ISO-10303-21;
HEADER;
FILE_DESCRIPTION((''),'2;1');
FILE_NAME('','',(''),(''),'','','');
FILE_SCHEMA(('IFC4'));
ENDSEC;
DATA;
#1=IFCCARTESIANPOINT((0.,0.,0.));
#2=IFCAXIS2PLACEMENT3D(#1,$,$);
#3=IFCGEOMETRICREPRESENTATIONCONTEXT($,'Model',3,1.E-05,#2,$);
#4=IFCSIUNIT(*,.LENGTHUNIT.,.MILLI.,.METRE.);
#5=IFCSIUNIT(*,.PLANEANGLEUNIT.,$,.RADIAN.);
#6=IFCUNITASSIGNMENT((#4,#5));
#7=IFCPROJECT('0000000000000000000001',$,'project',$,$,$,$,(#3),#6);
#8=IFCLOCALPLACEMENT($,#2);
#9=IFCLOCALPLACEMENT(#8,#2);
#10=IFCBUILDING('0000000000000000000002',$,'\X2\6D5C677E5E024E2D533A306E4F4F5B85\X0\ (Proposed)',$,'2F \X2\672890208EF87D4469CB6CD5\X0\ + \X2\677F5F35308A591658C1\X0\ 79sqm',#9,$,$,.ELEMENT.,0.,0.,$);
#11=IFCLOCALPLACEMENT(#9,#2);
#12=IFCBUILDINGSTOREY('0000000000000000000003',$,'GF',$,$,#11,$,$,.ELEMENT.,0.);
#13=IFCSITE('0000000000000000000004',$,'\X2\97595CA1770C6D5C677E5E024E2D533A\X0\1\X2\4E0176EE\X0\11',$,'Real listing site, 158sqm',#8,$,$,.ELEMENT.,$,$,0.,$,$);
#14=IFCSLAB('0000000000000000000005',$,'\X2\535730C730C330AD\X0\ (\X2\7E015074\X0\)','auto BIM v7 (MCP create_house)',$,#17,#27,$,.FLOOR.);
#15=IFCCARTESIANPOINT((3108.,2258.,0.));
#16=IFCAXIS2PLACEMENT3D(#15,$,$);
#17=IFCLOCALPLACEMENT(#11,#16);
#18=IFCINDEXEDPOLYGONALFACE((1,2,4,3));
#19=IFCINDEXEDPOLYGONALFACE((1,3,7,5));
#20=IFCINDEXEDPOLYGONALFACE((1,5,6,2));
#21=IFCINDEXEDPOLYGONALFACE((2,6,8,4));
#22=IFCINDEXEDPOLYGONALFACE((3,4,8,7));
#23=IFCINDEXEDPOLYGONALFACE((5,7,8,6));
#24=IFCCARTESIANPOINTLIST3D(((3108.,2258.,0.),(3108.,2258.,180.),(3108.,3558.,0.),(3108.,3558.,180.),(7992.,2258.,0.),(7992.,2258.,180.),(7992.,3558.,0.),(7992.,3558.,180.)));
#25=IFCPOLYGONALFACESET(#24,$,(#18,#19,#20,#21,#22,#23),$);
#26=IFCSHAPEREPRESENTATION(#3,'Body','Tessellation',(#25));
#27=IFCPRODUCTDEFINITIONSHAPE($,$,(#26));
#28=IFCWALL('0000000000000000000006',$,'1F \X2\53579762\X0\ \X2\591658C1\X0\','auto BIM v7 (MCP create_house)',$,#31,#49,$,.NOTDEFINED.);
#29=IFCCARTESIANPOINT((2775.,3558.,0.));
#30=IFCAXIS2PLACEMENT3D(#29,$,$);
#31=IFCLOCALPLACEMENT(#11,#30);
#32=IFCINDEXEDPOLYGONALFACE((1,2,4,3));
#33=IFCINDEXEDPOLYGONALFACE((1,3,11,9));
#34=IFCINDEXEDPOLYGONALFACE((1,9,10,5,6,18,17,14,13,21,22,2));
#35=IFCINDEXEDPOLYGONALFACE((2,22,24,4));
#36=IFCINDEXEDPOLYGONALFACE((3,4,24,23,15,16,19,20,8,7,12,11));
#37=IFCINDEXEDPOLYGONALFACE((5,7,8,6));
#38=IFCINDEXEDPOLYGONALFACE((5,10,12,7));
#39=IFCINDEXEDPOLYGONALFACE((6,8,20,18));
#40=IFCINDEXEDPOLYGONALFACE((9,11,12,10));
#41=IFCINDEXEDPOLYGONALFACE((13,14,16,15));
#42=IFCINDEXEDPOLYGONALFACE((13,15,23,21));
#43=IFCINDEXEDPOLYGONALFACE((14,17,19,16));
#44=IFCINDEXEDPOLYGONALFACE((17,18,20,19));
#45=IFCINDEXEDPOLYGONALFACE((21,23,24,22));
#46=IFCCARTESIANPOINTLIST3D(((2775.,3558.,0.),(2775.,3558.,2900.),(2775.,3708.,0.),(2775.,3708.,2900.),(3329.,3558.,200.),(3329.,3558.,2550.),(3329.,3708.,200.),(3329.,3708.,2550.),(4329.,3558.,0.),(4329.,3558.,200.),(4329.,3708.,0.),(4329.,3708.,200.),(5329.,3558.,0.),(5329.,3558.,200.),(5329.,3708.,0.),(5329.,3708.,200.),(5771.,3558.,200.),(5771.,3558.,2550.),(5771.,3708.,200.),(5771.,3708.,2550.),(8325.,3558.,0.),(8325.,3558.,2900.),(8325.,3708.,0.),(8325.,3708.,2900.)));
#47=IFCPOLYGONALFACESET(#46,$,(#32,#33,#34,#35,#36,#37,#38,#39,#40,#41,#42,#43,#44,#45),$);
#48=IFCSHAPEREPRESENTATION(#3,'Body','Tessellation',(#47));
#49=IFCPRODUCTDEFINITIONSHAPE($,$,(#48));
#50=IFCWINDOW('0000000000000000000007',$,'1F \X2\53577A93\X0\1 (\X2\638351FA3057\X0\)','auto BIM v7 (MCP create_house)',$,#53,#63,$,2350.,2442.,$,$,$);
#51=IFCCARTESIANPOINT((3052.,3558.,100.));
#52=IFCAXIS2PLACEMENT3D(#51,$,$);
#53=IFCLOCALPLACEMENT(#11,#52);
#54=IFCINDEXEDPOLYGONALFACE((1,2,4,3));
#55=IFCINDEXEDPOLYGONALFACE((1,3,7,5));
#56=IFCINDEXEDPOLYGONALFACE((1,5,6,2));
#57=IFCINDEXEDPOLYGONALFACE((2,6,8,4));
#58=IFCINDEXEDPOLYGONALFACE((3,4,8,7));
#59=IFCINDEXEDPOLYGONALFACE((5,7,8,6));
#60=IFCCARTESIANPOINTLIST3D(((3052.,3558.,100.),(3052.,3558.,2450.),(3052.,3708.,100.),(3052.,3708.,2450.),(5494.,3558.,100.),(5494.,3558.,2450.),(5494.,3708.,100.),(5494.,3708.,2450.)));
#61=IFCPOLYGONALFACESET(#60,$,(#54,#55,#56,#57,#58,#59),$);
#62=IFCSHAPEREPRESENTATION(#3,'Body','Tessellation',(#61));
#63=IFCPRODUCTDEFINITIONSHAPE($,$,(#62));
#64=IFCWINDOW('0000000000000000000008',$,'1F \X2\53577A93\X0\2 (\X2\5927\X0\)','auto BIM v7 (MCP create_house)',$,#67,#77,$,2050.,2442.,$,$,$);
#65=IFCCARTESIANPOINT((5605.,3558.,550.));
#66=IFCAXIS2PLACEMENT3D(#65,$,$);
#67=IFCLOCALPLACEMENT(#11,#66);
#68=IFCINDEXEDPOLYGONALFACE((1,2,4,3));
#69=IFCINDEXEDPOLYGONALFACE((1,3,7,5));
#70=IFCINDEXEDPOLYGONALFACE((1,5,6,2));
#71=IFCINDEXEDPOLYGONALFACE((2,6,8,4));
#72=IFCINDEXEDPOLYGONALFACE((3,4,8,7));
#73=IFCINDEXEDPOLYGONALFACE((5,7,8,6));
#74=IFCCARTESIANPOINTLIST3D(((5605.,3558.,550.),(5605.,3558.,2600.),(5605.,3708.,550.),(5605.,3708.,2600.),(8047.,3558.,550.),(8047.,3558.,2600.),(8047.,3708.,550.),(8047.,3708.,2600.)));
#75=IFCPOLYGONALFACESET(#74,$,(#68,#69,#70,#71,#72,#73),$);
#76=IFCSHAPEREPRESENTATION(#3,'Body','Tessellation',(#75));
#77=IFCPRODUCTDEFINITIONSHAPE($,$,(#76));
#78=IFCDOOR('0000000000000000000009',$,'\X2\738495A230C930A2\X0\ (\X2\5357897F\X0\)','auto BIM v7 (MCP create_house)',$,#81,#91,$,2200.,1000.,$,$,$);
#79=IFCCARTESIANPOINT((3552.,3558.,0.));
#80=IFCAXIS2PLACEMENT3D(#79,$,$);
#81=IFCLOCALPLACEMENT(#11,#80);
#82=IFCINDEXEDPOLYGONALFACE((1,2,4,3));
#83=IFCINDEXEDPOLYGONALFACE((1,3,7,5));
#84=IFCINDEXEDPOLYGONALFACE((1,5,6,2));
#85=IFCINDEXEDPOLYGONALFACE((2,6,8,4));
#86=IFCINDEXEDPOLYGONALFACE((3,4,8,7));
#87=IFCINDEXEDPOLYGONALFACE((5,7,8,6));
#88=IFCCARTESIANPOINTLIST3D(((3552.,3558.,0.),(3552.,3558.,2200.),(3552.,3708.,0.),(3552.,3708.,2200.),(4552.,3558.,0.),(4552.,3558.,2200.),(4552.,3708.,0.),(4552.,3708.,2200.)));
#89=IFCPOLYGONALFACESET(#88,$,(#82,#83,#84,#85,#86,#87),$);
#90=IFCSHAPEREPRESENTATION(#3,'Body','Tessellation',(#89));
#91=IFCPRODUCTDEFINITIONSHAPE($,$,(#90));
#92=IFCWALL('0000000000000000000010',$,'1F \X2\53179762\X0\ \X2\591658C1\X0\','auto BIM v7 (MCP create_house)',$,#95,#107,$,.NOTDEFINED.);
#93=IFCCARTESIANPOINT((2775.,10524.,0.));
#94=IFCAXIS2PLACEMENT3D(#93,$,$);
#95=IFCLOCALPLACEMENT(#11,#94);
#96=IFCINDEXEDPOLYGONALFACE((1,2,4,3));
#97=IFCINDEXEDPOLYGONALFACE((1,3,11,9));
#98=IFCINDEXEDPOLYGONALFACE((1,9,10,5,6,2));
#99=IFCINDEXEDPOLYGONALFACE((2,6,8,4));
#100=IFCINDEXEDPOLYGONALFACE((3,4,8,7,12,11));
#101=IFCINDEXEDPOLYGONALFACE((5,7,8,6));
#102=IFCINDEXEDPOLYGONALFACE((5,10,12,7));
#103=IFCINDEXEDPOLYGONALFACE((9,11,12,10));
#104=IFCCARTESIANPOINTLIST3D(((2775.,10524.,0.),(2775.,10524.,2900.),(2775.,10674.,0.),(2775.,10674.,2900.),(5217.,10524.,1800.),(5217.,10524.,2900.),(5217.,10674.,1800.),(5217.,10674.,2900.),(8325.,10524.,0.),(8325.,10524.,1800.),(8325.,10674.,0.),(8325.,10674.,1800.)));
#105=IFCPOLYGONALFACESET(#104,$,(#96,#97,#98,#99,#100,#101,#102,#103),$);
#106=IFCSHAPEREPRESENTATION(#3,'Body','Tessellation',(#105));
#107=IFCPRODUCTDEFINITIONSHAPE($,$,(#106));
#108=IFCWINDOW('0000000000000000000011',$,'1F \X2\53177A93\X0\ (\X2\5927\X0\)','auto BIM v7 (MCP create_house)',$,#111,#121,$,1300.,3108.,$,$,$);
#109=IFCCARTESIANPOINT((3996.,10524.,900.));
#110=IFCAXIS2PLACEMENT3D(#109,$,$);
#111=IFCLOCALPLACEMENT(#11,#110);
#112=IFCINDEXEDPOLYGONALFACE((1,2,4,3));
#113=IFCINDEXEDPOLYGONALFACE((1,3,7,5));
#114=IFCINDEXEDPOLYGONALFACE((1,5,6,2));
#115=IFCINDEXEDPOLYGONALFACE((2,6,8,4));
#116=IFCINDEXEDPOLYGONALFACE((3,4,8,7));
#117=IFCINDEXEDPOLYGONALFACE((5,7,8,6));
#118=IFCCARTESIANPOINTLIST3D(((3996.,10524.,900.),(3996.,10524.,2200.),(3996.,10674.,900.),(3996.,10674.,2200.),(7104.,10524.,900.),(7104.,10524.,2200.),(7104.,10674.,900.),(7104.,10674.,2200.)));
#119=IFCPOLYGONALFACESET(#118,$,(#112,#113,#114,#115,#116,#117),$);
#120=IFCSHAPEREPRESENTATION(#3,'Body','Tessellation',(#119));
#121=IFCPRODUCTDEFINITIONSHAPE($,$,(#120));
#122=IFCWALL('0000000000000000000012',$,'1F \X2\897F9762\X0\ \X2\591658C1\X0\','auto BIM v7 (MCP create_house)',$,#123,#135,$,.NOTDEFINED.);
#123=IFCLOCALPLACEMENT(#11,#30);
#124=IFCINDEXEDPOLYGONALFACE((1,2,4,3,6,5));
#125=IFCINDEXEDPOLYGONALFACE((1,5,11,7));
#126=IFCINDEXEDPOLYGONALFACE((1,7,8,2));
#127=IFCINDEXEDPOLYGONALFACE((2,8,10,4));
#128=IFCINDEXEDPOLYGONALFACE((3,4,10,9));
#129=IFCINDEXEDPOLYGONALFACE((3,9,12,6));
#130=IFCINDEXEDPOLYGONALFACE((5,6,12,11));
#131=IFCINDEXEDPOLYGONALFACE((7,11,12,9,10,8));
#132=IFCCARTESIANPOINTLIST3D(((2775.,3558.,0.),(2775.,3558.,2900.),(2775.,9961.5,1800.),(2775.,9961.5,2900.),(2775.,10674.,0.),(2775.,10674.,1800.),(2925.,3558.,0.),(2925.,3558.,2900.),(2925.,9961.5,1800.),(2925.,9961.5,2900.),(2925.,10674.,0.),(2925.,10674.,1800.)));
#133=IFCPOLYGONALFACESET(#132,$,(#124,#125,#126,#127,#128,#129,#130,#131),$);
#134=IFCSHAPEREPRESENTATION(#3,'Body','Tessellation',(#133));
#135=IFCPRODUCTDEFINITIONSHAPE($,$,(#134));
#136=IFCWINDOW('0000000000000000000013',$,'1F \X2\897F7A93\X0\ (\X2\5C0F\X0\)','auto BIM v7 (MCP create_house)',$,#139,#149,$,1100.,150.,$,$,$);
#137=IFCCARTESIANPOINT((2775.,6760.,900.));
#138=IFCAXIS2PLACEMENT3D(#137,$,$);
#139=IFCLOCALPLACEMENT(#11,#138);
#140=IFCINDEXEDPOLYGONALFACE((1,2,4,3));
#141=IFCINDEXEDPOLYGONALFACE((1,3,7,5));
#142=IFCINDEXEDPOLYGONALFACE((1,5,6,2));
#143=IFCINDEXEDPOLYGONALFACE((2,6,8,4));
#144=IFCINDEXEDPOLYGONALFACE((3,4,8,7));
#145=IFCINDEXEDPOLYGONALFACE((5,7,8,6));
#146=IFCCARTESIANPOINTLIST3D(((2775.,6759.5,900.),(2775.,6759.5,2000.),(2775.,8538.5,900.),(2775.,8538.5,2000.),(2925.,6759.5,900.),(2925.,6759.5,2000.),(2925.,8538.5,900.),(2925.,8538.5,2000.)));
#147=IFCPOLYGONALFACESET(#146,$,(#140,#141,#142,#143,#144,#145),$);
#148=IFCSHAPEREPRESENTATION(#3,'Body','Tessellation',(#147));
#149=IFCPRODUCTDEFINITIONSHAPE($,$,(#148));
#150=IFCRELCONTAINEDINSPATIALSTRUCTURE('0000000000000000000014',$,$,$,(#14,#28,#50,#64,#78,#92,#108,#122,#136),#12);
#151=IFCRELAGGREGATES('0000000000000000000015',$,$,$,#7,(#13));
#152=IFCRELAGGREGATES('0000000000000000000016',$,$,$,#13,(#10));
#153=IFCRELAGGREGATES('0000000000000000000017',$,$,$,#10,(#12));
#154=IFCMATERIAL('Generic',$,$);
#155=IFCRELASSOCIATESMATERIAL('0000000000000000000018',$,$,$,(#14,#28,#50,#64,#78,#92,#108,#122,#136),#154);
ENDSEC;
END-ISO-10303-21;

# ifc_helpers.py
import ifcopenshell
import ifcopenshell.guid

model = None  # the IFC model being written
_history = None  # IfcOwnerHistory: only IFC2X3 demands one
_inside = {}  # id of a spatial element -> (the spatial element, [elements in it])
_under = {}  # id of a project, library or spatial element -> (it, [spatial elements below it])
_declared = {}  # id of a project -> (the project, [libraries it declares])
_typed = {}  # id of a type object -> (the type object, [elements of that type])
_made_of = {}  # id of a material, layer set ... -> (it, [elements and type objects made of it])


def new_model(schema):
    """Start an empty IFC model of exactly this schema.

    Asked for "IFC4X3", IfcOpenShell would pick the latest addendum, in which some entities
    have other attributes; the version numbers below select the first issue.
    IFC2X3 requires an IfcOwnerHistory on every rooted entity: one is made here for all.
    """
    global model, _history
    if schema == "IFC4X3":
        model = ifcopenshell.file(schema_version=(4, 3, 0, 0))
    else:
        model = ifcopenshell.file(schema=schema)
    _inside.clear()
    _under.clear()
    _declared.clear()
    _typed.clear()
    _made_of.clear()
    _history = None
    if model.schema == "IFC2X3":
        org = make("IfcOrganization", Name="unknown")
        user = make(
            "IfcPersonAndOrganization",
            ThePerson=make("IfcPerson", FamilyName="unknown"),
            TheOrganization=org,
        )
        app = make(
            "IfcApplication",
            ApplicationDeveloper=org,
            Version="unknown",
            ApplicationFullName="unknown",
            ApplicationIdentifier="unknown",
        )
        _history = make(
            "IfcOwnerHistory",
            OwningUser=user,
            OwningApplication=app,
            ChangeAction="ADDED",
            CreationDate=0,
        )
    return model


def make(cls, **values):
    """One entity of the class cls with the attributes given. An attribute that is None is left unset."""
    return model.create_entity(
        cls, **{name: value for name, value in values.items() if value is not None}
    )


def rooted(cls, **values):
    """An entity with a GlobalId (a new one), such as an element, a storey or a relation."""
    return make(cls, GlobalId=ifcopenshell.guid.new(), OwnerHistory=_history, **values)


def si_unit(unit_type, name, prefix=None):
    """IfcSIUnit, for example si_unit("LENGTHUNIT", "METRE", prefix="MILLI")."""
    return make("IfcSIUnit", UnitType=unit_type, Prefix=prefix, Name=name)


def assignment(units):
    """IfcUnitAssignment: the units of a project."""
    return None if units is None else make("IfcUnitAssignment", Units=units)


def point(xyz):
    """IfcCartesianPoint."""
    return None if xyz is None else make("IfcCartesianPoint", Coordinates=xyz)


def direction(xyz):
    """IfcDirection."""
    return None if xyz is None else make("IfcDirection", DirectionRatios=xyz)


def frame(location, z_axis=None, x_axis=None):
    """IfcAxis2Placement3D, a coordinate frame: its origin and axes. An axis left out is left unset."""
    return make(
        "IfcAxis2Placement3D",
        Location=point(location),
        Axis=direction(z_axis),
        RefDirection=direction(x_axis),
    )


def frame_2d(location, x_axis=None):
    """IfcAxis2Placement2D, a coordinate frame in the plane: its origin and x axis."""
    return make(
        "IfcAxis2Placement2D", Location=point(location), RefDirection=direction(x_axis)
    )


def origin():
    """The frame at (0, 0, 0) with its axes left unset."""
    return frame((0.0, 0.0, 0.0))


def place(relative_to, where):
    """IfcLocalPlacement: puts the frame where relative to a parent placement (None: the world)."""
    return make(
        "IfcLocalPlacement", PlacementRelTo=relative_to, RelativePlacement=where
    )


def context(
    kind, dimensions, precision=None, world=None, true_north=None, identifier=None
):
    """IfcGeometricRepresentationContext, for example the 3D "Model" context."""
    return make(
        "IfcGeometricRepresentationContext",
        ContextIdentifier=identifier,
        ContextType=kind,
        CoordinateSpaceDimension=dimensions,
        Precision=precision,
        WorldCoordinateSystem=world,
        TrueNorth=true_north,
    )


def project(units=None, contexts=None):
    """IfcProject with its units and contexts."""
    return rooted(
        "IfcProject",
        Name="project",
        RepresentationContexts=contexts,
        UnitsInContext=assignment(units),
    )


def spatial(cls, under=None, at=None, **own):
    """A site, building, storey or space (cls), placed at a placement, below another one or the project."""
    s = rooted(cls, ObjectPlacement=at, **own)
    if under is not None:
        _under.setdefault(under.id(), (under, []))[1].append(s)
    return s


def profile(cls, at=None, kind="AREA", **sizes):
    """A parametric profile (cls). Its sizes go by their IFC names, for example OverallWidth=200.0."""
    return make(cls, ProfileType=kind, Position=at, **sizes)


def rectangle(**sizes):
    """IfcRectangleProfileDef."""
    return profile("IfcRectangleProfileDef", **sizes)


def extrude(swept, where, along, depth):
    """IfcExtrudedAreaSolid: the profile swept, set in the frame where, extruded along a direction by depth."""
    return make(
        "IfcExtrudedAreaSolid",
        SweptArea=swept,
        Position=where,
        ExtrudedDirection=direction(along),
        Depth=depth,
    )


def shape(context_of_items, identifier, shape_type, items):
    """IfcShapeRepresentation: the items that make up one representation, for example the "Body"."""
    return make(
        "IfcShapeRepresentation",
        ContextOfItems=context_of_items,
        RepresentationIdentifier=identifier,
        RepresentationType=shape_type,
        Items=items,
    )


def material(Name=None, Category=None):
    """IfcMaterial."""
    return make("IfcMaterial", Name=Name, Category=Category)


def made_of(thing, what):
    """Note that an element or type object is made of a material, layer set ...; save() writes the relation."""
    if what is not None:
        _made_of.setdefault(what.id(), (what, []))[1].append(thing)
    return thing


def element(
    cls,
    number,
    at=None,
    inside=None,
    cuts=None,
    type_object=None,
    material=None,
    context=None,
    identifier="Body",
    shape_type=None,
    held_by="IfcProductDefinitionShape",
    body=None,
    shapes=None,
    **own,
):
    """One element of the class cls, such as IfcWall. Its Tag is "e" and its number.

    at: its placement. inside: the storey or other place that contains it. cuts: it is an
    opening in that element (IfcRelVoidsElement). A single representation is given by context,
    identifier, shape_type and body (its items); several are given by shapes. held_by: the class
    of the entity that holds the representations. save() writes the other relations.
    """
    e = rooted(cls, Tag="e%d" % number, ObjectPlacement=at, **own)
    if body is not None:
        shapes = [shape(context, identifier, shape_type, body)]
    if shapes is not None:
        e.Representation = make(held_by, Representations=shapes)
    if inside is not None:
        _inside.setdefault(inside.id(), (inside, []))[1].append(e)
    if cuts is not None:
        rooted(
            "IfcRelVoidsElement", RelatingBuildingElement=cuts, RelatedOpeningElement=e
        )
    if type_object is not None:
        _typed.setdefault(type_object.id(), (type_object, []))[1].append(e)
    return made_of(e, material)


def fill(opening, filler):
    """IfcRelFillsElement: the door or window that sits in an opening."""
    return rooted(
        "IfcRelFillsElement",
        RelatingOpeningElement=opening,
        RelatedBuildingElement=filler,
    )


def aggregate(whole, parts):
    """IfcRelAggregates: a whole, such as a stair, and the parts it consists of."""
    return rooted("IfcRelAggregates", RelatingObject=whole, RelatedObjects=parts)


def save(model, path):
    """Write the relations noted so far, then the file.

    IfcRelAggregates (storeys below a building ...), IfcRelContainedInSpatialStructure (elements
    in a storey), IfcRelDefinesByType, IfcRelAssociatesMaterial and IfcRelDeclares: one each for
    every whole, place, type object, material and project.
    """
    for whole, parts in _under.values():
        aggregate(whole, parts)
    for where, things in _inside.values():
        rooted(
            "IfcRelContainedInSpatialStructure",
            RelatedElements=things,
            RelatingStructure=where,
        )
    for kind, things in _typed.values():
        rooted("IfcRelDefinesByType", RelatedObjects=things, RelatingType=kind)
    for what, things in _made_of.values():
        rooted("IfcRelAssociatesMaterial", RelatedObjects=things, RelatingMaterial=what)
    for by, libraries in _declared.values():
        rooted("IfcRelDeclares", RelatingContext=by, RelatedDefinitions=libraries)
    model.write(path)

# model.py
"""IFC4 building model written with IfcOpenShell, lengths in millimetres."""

from ifc_helpers import new_model, si_unit, frame, frame_2d, origin, place, context, project, spatial, rectangle, extrude, material, element, fill, save


model = new_model("IFC4")

# Units and contexts
model_context = context("Model", 3, precision=1e-05, world=origin())
ifc_project = project(units=[si_unit("LENGTHUNIT", "METRE", prefix="MILLI"), si_unit("PLANEANGLEUNIT", "RADIAN")], contexts=[model_context])

# Site, building, storey
site_placement = place(None, origin())
site = spatial("IfcSite", under=ifc_project, at=site_placement, Name="静岡県浜松市中区1丁目11", ObjectType="Real listing site, 158sqm", CompositionType="ELEMENT", RefElevation=0.0)
building_placement = place(site_placement, origin())
building = spatial("IfcBuilding", under=site, at=building_placement, Name="浜松市中区の住宅 (Proposed)", ObjectType="2F 木造軸組構法 + 板張り外壁 79sqm", CompositionType="ELEMENT", ElevationOfRefHeight=0.0, ElevationOfTerrain=0.0)
storey_placement = place(building_placement, origin())
storey = spatial("IfcBuildingStorey", under=building, at=storey_placement, Name="GF", CompositionType="ELEMENT", Elevation=0.0)

# Slab
ifc_material = material(Name="Generic")
slab_1_placement = place(storey_placement, frame((3108.0, 2258.0, 0.0)))
element("IfcSlab", 1, at=slab_1_placement, inside=storey, material=ifc_material, Name="南デッキ (縁側)", Description="auto BIM v7 (MCP create_house)", PredefinedType="FLOOR", context=model_context, shape_type="SweptSolid", body=[
    extrude(rectangle(XDim=4884.0, YDim=1300.0, at=frame_2d((2442.0, 650.0))), frame((3108.0, 2258.0, 0.0)), (0.0, 0.0, 1.0), 180.0),
])

# Wall, openings, windows, door
wall_1_placement = place(storey_placement, frame((2775.0, 3558.0, 0.0)))
wall_1 = element("IfcWall", 2, at=wall_1_placement, inside=storey, material=ifc_material, Name="1F 南面 外壁", Description="auto BIM v7 (MCP create_house)", PredefinedType="NOTDEFINED", context=model_context, shape_type="SweptSolid", body=[
    extrude(rectangle(XDim=5550.0, YDim=150.0, at=frame_2d((2775.0, 75.0))), frame((2775.0, 3558.0, 0.0)), (0.0, 0.0, 1.0), 2900.0),
])
opening_1_placement = place(storey_placement, frame((3052.0, 3558.0, 100.0)))
opening_1 = element("IfcOpeningElement", 3, at=opening_1_placement, cuts=wall_1, PredefinedType="NOTDEFINED", context=model_context, shape_type="SweptSolid", body=[
    extrude(rectangle(XDim=2442.0, YDim=150.0, at=frame_2d((1221.0, 75.0))), frame((3052.0, 3558.0, 100.0)), (0.0, 0.0, 1.0), 2350.0),
])
opening_2_placement = place(storey_placement, frame((5605.0, 3558.0, 550.0)))
opening_2 = element("IfcOpeningElement", 4, at=opening_2_placement, cuts=wall_1, PredefinedType="NOTDEFINED", context=model_context, shape_type="SweptSolid", body=[
    extrude(rectangle(XDim=2442.0, YDim=150.0, at=frame_2d((1221.0, 75.0))), frame((5605.0, 3558.0, 550.0)), (0.0, 0.0, 1.0), 2050.0),
])
opening_3_placement = place(storey_placement, frame((3552.0, 3558.0, 0.0)))
opening_3 = element("IfcOpeningElement", 5, at=opening_3_placement, cuts=wall_1, PredefinedType="NOTDEFINED", context=model_context, shape_type="SweptSolid", body=[
    extrude(rectangle(XDim=1000.0, YDim=150.0, at=frame_2d((500.0, 75.0))), frame((3552.0, 3558.0, 0.0)), (0.0, 0.0, 1.0), 2200.0),
])
window_1_placement = place(storey_placement, frame((3052.0, 3558.0, 100.0)))
window_1 = element("IfcWindow", 6, at=window_1_placement, inside=storey, material=ifc_material, Name="1F 南窓1 (掃出し)", Description="auto BIM v7 (MCP create_house)", OverallHeight=2350.0, OverallWidth=2442.0, context=model_context, shape_type="SweptSolid", body=[
    extrude(rectangle(XDim=2442.0, YDim=150.0, at=frame_2d((1221.0, 75.0))), frame((3052.0, 3558.0, 100.0)), (0.0, 0.0, 1.0), 2350.0),
])
fill(opening_1, window_1)
window_2_placement = place(storey_placement, frame((5605.0, 3558.0, 550.0)))
window_2 = element("IfcWindow", 7, at=window_2_placement, inside=storey, material=ifc_material, Name="1F 南窓2 (大)", Description="auto BIM v7 (MCP create_house)", OverallHeight=2050.0, OverallWidth=2442.0, context=model_context, shape_type="SweptSolid", body=[
    extrude(rectangle(XDim=2442.0, YDim=150.0, at=frame_2d((1221.0, 75.0))), frame((5605.0, 3558.0, 550.0)), (0.0, 0.0, 1.0), 2050.0),
])
fill(opening_2, window_2)
door_placement = place(storey_placement, frame((3552.0, 3558.0, 0.0)))
door = element("IfcDoor", 8, at=door_placement, inside=storey, material=ifc_material, Name="玄関ドア (南西)", Description="auto BIM v7 (MCP create_house)", OverallHeight=2200.0, OverallWidth=1000.0, context=model_context, shape_type="SweptSolid", body=[
    extrude(rectangle(XDim=1000.0, YDim=150.0, at=frame_2d((500.0, 75.0))), frame((3552.0, 3558.0, 0.0)), (0.0, 0.0, 1.0), 2200.0),
])
fill(opening_3, door)

# Walls, openings, windows
wall_2_placement = place(storey_placement, frame((2775.0, 10524.0, 0.0)))
wall_2 = element("IfcWall", 9, at=wall_2_placement, inside=storey, material=ifc_material, Name="1F 北面 外壁", Description="auto BIM v7 (MCP create_house)", PredefinedType="NOTDEFINED", context=model_context, shape_type="SweptSolid", body=[
    extrude(rectangle(XDim=5550.0, YDim=150.0, at=frame_2d((2775.0, 75.0))), frame((2775.0, 10524.0, 0.0)), (0.0, 0.0, 1.0), 2900.0),
])
opening_4_placement = place(storey_placement, frame((3996.0, 10524.0, 900.0)))
opening_4 = element("IfcOpeningElement", 10, at=opening_4_placement, cuts=wall_2, PredefinedType="NOTDEFINED", context=model_context, shape_type="SweptSolid", body=[
    extrude(rectangle(XDim=3108.0, YDim=150.0, at=frame_2d((1554.0, 75.0))), frame((3996.0, 10524.0, 900.0)), (0.0, 0.0, 1.0), 1300.0),
])
window_3_placement = place(storey_placement, frame((3996.0, 10524.0, 900.0)))
window_3 = element("IfcWindow", 11, at=window_3_placement, inside=storey, material=ifc_material, Name="1F 北窓 (大)", Description="auto BIM v7 (MCP create_house)", OverallHeight=1300.0, OverallWidth=3108.0, context=model_context, shape_type="SweptSolid", body=[
    extrude(rectangle(XDim=3108.0, YDim=150.0, at=frame_2d((1554.0, 75.0))), frame((3996.0, 10524.0, 900.0)), (0.0, 0.0, 1.0), 1300.0),
])
fill(opening_4, window_3)
wall_3_placement = place(storey_placement, frame((2775.0, 3558.0, 0.0)))
wall_3 = element("IfcWall", 12, at=wall_3_placement, inside=storey, material=ifc_material, Name="1F 西面 外壁", Description="auto BIM v7 (MCP create_house)", PredefinedType="NOTDEFINED", context=model_context, shape_type="SweptSolid", body=[
    extrude(rectangle(XDim=150.0, YDim=7116.0, at=frame_2d((75.0, 3558.0))), frame((2775.0, 3558.0, 0.0)), (0.0, 0.0, 1.0), 2900.0),
])
opening_5_placement = place(storey_placement, frame((2775.0, 6760.0, 900.0)))
opening_5 = element("IfcOpeningElement", 13, at=opening_5_placement, cuts=wall_3, PredefinedType="NOTDEFINED", context=model_context, shape_type="SweptSolid", body=[
    extrude(rectangle(XDim=150.0, YDim=1779.0, at=frame_2d((75.0, 889.0))), frame((2775.0, 6760.0, 900.0)), (0.0, 0.0, 1.0), 1100.0),
])
window_4_placement = place(storey_placement, frame((2775.0, 6760.0, 900.0)))
window_4 = element("IfcWindow", 14, at=window_4_placement, inside=storey, material=ifc_material, Name="1F 西窓 (小)", Description="auto BIM v7 (MCP create_house)", OverallHeight=1100.0, OverallWidth=150.0, context=model_context, shape_type="SweptSolid", body=[
    extrude(rectangle(XDim=150.0, YDim=1779.0, at=frame_2d((75.0, 889.0))), frame((2775.0, 6760.0, 900.0)), (0.0, 0.0, 1.0), 1100.0),
])
fill(opening_5, window_4)

save(model, "model.ifc")
